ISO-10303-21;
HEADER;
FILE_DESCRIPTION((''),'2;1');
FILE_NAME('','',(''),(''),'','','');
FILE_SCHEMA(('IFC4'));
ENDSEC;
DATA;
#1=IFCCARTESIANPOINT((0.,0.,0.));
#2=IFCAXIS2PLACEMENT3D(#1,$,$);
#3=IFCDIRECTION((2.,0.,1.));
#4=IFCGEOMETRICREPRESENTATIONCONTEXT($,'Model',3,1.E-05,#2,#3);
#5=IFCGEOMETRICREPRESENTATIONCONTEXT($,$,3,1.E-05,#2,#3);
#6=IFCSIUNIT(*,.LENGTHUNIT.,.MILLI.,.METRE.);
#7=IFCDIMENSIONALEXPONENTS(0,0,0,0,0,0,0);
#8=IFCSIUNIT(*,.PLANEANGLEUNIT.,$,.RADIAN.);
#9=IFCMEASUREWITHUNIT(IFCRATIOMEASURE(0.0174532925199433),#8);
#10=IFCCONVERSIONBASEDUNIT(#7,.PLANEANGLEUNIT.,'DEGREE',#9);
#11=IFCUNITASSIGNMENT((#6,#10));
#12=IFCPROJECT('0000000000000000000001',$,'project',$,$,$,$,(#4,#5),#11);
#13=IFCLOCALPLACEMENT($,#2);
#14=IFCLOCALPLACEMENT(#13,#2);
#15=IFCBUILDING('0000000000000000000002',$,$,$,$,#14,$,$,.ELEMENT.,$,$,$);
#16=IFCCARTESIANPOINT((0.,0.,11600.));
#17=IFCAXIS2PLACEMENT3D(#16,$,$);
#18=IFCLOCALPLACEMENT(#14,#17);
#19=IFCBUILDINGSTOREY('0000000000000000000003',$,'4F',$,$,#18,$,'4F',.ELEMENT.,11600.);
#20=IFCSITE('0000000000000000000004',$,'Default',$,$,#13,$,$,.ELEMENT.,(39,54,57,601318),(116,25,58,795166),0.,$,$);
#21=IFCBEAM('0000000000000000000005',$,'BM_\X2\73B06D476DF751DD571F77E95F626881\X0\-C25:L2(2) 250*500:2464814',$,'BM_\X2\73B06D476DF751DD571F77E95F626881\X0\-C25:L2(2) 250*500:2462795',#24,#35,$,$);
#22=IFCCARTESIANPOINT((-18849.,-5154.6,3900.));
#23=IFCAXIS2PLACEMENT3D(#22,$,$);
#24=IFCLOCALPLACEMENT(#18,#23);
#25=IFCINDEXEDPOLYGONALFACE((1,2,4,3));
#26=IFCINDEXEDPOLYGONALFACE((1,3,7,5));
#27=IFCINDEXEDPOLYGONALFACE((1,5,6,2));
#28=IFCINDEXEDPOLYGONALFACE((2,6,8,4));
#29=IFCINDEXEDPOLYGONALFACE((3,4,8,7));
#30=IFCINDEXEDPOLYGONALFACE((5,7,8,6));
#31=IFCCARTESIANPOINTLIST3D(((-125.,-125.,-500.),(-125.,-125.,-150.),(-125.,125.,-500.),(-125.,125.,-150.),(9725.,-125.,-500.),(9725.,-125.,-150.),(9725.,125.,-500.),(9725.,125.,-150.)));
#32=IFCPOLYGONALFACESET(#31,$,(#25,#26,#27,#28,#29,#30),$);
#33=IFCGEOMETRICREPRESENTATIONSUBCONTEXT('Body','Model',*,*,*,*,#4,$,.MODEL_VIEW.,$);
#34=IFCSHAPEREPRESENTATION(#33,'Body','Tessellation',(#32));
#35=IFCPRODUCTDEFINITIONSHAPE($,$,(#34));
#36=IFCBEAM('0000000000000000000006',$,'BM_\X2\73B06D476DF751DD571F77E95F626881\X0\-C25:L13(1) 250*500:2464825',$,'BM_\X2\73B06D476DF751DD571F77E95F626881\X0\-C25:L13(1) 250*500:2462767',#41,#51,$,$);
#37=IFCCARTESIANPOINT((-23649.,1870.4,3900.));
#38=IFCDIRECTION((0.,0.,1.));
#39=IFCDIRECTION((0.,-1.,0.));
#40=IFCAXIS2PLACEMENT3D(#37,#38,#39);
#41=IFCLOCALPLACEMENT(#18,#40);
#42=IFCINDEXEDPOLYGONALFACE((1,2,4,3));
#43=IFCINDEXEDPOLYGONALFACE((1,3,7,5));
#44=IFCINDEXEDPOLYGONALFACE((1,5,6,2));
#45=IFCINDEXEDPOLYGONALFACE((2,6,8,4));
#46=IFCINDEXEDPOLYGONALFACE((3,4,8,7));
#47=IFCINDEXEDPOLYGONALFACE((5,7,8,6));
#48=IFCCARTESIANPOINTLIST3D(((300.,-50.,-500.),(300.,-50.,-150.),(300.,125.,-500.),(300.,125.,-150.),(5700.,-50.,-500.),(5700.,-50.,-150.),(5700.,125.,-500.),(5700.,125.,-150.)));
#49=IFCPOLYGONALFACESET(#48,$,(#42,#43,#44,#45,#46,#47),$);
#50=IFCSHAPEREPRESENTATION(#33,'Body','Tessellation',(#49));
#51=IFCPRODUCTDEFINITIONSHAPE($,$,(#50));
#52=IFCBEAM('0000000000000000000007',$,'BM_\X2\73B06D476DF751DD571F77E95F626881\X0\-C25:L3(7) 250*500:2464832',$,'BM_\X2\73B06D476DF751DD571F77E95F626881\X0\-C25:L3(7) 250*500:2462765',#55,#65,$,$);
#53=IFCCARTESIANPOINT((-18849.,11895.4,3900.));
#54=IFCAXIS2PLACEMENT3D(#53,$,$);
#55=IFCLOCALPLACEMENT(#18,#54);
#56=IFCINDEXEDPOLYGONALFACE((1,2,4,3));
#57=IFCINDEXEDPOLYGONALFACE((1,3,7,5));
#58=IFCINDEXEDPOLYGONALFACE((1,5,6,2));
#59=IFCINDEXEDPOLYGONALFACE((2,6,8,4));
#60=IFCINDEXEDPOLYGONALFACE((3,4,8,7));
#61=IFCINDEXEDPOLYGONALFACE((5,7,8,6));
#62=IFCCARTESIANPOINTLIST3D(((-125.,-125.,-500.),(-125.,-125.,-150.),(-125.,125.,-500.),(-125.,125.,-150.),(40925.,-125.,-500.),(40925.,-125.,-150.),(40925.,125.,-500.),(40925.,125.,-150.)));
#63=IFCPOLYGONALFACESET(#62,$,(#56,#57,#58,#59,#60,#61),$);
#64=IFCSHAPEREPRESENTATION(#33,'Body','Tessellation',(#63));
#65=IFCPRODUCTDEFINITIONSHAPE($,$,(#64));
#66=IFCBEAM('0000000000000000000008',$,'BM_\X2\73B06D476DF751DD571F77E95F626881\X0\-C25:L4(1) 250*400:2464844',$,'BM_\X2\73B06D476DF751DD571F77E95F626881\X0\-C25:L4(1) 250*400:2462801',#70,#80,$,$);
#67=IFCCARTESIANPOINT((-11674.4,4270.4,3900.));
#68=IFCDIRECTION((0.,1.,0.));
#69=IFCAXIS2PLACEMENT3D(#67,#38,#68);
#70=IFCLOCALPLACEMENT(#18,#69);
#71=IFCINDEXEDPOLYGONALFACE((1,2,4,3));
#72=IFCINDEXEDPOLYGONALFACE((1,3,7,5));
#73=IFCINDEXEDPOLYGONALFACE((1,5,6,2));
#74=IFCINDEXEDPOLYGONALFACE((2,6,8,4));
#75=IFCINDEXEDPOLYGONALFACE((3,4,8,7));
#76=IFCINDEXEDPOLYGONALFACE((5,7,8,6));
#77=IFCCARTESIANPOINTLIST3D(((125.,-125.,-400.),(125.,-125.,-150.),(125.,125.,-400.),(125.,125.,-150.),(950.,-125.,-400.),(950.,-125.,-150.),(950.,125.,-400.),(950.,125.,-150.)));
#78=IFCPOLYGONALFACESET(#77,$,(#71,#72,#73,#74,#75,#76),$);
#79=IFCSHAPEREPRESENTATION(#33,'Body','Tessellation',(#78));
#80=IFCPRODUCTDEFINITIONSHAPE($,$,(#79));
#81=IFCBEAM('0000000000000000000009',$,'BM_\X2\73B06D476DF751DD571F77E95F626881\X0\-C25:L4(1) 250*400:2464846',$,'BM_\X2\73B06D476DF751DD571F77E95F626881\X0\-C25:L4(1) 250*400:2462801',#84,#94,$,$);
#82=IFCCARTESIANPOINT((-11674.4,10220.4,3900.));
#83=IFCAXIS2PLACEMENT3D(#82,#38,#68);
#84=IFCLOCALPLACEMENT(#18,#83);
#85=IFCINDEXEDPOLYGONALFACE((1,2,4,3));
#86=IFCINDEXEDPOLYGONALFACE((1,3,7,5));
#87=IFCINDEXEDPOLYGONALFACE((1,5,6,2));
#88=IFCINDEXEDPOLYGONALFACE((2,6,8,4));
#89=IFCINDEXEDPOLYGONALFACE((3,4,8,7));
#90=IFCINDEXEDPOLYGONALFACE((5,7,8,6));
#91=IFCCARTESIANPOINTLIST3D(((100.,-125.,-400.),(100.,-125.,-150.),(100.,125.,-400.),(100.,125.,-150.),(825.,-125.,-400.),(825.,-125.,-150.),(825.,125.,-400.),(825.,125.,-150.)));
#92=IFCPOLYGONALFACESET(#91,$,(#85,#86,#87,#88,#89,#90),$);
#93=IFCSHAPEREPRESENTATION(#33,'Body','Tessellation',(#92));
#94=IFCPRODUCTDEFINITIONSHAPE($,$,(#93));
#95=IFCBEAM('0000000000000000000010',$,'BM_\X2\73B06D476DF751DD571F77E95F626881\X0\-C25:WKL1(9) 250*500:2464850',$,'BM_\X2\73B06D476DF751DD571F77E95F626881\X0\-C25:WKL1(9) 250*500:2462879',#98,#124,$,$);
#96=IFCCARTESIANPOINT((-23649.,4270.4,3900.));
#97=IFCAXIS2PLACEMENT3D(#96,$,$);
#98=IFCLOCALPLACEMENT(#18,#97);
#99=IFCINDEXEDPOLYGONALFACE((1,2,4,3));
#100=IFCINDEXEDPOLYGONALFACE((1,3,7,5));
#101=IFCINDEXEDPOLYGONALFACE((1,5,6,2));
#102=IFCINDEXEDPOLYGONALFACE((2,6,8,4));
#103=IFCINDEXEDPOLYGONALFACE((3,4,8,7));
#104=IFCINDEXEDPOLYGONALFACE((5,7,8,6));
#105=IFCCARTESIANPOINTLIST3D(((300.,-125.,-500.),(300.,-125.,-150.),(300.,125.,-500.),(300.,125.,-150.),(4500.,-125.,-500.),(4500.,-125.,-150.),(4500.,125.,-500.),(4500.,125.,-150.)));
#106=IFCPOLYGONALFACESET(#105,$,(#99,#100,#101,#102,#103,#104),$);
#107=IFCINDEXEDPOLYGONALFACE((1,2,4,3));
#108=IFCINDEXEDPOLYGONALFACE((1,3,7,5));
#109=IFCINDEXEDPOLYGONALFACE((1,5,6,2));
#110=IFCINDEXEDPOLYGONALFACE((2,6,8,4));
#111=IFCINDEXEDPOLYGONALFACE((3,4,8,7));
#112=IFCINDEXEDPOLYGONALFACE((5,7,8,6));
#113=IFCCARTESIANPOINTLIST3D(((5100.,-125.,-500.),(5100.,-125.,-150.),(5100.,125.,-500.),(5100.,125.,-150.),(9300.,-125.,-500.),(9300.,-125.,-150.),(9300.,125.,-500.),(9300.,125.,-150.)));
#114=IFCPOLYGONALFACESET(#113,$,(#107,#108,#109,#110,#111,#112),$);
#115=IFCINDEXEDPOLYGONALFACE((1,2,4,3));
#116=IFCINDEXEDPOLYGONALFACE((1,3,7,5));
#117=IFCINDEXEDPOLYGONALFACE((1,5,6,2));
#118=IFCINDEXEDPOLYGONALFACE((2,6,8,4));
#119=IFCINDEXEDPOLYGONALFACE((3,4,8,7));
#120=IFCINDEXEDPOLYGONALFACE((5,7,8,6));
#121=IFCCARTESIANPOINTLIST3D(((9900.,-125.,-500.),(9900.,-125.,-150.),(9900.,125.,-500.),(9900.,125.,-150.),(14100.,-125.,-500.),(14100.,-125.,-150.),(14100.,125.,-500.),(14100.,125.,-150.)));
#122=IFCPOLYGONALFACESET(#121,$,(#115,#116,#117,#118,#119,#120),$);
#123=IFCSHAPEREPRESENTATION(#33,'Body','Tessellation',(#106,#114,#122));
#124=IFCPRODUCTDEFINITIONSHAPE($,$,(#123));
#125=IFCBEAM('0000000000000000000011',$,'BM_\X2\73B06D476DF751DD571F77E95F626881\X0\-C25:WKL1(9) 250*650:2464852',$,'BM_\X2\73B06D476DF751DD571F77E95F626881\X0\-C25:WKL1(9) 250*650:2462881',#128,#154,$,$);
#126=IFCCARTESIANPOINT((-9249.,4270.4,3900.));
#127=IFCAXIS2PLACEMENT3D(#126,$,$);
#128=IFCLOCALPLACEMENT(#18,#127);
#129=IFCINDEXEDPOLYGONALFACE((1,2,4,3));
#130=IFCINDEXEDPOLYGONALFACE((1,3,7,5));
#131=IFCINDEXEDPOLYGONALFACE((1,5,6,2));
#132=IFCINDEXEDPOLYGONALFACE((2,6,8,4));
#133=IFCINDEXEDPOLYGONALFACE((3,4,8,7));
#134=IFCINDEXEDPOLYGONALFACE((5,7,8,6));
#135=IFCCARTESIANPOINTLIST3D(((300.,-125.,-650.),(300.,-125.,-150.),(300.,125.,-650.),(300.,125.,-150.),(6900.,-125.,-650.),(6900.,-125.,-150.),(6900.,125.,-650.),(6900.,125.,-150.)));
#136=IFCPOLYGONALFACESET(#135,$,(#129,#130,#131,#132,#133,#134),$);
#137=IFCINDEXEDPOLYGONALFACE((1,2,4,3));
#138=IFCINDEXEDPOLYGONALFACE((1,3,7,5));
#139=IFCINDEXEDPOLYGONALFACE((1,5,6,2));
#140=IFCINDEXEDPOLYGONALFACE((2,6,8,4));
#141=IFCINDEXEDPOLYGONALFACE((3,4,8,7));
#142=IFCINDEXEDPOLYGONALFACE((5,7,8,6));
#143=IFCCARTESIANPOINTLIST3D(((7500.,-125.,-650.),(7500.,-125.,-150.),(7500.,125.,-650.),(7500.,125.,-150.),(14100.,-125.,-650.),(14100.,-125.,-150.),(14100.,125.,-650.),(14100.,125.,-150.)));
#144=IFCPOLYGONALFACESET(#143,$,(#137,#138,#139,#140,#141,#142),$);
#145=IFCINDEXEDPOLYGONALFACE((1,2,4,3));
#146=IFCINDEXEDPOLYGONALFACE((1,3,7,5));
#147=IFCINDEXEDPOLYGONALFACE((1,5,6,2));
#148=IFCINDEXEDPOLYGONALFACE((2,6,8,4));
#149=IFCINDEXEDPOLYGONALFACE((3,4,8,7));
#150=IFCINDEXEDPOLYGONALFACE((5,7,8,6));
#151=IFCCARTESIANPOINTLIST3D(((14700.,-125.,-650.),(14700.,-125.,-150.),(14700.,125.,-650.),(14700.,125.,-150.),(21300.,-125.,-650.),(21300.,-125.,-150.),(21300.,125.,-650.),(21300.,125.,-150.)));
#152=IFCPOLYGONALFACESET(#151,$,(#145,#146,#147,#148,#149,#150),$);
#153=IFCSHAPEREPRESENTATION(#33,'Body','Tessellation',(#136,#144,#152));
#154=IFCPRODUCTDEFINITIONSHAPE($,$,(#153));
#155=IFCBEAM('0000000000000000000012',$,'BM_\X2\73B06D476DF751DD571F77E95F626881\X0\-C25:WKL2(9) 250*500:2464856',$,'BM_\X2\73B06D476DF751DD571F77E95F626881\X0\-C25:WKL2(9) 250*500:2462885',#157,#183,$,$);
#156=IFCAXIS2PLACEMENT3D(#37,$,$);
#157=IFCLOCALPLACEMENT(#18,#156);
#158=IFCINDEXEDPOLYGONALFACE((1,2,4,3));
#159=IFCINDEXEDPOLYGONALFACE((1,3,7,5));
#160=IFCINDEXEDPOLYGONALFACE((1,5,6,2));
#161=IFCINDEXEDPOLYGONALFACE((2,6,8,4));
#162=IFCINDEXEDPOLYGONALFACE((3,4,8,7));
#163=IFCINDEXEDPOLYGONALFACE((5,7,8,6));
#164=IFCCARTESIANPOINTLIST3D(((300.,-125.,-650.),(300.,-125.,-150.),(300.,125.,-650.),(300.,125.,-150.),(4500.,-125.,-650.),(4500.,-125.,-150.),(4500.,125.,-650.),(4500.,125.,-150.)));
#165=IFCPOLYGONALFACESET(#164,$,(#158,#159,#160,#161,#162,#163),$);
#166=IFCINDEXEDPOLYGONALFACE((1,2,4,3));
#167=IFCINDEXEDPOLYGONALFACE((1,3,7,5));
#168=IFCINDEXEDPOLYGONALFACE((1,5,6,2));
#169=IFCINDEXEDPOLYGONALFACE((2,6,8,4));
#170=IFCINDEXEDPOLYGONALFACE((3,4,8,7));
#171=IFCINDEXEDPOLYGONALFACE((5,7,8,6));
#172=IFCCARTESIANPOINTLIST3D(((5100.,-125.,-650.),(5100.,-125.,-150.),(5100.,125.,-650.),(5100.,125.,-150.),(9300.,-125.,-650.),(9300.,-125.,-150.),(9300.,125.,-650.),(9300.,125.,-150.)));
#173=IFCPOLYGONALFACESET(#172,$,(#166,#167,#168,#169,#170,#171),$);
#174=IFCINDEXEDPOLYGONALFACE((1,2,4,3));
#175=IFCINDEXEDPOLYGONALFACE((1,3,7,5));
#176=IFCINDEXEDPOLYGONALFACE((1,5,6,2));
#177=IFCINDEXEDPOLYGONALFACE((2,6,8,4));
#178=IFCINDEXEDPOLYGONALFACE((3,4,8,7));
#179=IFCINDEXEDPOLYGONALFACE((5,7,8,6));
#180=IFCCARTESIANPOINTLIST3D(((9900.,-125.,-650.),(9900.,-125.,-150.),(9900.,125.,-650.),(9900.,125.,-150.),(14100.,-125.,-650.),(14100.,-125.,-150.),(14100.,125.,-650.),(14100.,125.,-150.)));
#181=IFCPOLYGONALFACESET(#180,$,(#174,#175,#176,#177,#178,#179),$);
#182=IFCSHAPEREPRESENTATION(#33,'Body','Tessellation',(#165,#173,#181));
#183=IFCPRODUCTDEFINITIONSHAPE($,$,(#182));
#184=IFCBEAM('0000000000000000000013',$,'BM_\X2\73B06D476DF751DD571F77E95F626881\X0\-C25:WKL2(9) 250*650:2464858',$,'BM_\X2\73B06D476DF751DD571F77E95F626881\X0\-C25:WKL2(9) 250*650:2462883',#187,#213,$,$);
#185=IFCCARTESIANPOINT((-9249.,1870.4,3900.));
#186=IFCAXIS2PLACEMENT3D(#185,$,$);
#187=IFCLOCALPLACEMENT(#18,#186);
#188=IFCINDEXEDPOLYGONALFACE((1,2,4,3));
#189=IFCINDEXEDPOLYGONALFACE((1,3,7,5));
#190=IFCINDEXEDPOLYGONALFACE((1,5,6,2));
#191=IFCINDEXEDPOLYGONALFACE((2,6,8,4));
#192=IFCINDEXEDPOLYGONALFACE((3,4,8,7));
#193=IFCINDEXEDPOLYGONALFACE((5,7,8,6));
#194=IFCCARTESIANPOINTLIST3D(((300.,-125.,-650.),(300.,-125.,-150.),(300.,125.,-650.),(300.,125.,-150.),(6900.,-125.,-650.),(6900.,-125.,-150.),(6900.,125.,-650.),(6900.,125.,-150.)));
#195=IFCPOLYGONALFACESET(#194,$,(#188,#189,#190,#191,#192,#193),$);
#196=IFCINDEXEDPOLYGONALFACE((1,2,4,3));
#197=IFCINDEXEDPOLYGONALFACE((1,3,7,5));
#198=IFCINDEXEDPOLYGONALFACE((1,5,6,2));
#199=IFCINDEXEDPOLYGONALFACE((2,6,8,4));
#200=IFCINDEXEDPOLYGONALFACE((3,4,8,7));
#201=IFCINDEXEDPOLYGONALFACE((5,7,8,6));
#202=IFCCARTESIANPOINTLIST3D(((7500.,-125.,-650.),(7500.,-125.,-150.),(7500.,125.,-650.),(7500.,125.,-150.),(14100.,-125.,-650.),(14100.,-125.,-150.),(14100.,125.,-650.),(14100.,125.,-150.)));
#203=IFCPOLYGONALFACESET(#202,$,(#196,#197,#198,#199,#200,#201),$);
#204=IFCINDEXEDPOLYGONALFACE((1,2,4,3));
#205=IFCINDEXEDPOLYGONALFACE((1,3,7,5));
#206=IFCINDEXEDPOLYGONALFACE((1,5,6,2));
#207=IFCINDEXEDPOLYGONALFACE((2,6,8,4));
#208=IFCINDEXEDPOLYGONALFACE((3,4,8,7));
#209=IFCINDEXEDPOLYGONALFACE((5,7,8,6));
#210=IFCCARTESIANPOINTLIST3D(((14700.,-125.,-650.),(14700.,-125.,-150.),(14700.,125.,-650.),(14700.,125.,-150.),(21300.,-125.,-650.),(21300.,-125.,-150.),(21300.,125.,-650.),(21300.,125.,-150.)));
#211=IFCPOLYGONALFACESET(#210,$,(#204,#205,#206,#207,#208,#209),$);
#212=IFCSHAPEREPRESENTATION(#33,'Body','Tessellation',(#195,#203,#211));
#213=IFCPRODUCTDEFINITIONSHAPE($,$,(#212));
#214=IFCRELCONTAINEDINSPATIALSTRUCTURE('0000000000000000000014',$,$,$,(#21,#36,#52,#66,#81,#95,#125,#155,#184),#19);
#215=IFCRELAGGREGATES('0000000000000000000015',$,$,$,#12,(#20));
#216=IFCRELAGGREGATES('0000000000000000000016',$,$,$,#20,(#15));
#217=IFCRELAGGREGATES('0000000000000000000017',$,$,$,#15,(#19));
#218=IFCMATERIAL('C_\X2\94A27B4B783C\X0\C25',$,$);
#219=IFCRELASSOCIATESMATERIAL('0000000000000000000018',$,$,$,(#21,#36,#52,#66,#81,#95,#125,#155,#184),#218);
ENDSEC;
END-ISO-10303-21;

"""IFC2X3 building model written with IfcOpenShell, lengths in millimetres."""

from ifc_helpers import new_model, entity, si_unit, converted_unit, direction, frame, frame_2d, origin, origin_2d_with_axis, place, context, subcontext, project, spatial, rectangle, extrude, material, element, save


model = new_model("IFC2X3")

# Units and contexts
model_context = context("Model", 3, precision=1e-05, world=origin(), true_north=direction((2.0, 0.0, 1.0)))
context_of_model = context(None, 3, precision=1e-05, world=origin(), true_north=direction((2.0, 0.0, 1.0)))
body_context = subcontext(model_context, "Body", "Model", "MODEL_VIEW")
ifc_project = project(units=[si_unit("LENGTHUNIT", "METRE", prefix="MILLI"), converted_unit("PLANEANGLEUNIT", "DEGREE", entity("IfcRatioMeasure", 0.0174532925199433), si_unit("PLANEANGLEUNIT", "RADIAN"), dimensions=[0, 0, 0, 0, 0, 0, 0])], contexts=[model_context, context_of_model])

# Site, building, storey
site_placement = place(None, origin())
site = spatial("IfcSite", under=ifc_project, at=site_placement, Name="Default", CompositionType="ELEMENT", RefLatitude=(39, 54, 57, 601318), RefLongitude=(116, 25, 58, 795166), RefElevation=0.0)
building_placement = place(site_placement, origin())
building = spatial("IfcBuilding", under=site, at=building_placement, CompositionType="ELEMENT")
storey_placement = place(building_placement, frame((0.0, 0.0, 11600.0)))
storey = spatial("IfcBuildingStorey", under=building, at=storey_placement, Name="4F", LongName="4F", CompositionType="ELEMENT", Elevation=11600.0)

# Beams
ifc_material = material(Name="C_钢筋砼C25")
beam_1_placement = place(storey_placement, frame((-18849.0, -5154.6, 3900.0)))
element("IfcBeam", 1, at=beam_1_placement, inside=storey, material=ifc_material, Name="BM_现浇混凝土矩形梁-C25:L2(2) 250*500:2464814", ObjectType="BM_现浇混凝土矩形梁-C25:L2(2) 250*500:2462795", context=body_context, shape_type="SweptSolid", body=[
    extrude(rectangle(XDim=350.0, YDim=250.0, at=frame_2d((0.0, 0.0), x_axis=(1.0, 0.0))), frame((-125.0, 0.0, -325.0), z_axis=(1.0, 0.0, 0.0), x_axis=(0.0, 0.0, -1.0)), (0.0, 0.0, 1.0), 9850.0),
])
beam_2_placement = place(storey_placement, frame((-23649.0, 1870.4, 3900.0), z_axis=(0.0, 0.0, 1.0), x_axis=(0.0, -1.0, 0.0)))
element("IfcBeam", 2, at=beam_2_placement, inside=storey, material=ifc_material, Name="BM_现浇混凝土矩形梁-C25:L13(1) 250*500:2464825", ObjectType="BM_现浇混凝土矩形梁-C25:L13(1) 250*500:2462767", context=body_context, shape_type="SweptSolid", body=[
    extrude(rectangle(XDim=350.0, YDim=175.0, at=frame_2d((0.0, 0.0), x_axis=(1.0, 0.0))), frame((300.0, 37.5, -325.0), z_axis=(1.0, 0.0, 0.0), x_axis=(0.0, 0.0, -1.0)), (0.0, 0.0, 1.0), 5400.0),
])
beam_3_placement = place(storey_placement, frame((-18849.0, 11895.4, 3900.0)))
element("IfcBeam", 3, at=beam_3_placement, inside=storey, material=ifc_material, Name="BM_现浇混凝土矩形梁-C25:L3(7) 250*500:2464832", ObjectType="BM_现浇混凝土矩形梁-C25:L3(7) 250*500:2462765", context=body_context, shape_type="SweptSolid", body=[
    extrude(rectangle(XDim=350.0, YDim=250.0, at=frame_2d((0.0, 0.0), x_axis=(1.0, 0.0))), frame((-125.0, 0.0, -325.0), z_axis=(1.0, 0.0, 0.0), x_axis=(0.0, 0.0, -1.0)), (0.0, 0.0, 1.0), 41050.0),
])
beam_4_placement = place(storey_placement, frame((-11674.4, 4270.4, 3900.0), z_axis=(0.0, 0.0, 1.0), x_axis=(0.0, 1.0, 0.0)))
element("IfcBeam", 4, at=beam_4_placement, inside=storey, material=ifc_material, Name="BM_现浇混凝土矩形梁-C25:L4(1) 250*400:2464844", ObjectType="BM_现浇混凝土矩形梁-C25:L4(1) 250*400:2462801", context=body_context, shape_type="SweptSolid", body=[
    extrude(rectangle(XDim=250.0, YDim=250.0, at=frame_2d((0.0, 0.0), x_axis=(1.0, 0.0))), frame((125.0, 0.0, -275.0), z_axis=(1.0, 0.0, 0.0), x_axis=(0.0, 0.0, -1.0)), (0.0, 0.0, 1.0), 825.0),
])
beam_5_placement = place(storey_placement, frame((-11674.4, 10220.4, 3900.0), z_axis=(0.0, 0.0, 1.0), x_axis=(0.0, 1.0, 0.0)))
element("IfcBeam", 5, at=beam_5_placement, inside=storey, material=ifc_material, Name="BM_现浇混凝土矩形梁-C25:L4(1) 250*400:2464846", ObjectType="BM_现浇混凝土矩形梁-C25:L4(1) 250*400:2462801", context=body_context, shape_type="SweptSolid", body=[
    extrude(rectangle(XDim=250.0, YDim=250.0, at=frame_2d((0.0, 0.0), x_axis=(1.0, 0.0))), frame((100.0, 0.0, -275.0), z_axis=(1.0, 0.0, 0.0), x_axis=(0.0, 0.0, -1.0)), (0.0, 0.0, 1.0), 725.0),
])
beam_6_placement = place(storey_placement, frame((-23649.0, 4270.4, 3900.0)))
element("IfcBeam", 6, at=beam_6_placement, inside=storey, material=ifc_material, Name="BM_现浇混凝土矩形梁-C25:WKL1(9) 250*500:2464850", ObjectType="BM_现浇混凝土矩形梁-C25:WKL1(9) 250*500:2462879", context=body_context, shape_type="SweptSolid", body=[
    extrude(rectangle(XDim=350.0, YDim=250.0, at=frame_2d((0.0, 0.0), x_axis=(1.0, 0.0))), frame((300.0, 0.0, -325.0), z_axis=(1.0, 0.0, 0.0), x_axis=(0.0, 0.0, 1.0)), (0.0, 0.0, 1.0), 4200.0),
    extrude(rectangle(XDim=350.0, YDim=250.0, at=origin_2d_with_axis()), frame((5100.0, 0.0, -325.0), z_axis=(1.0, 0.0, 0.0), x_axis=(0.0, 0.0, 1.0)), (0.0, 0.0, 1.0), 4200.0),
    extrude(rectangle(XDim=350.0, YDim=250.0, at=frame_2d((0.0, 0.0), x_axis=(1.0, 0.0))), frame((9900.0, 0.0, -325.0), z_axis=(1.0, 0.0, 0.0), x_axis=(0.0, 0.0, 1.0)), (0.0, 0.0, 1.0), 4200.0),
])
beam_7_placement = place(storey_placement, frame((-9249.0, 4270.4, 3900.0)))
element("IfcBeam", 7, at=beam_7_placement, inside=storey, material=ifc_material, Name="BM_现浇混凝土矩形梁-C25:WKL1(9) 250*650:2464852", ObjectType="BM_现浇混凝土矩形梁-C25:WKL1(9) 250*650:2462881", context=body_context, shape_type="SweptSolid", body=[
    extrude(rectangle(XDim=500.0, YDim=250.0, at=frame_2d((0.0, 0.0), x_axis=(1.0, 0.0))), frame((300.0, 0.0, -400.0), z_axis=(1.0, 0.0, 0.0), x_axis=(0.0, 0.0, 1.0)), (0.0, 0.0, 1.0), 6600.0),
    extrude(rectangle(XDim=500.0, YDim=250.0, at=frame_2d((0.0, 0.0), x_axis=(1.0, 0.0))), frame((7500.0, 0.0, -400.0), z_axis=(1.0, 0.0, 0.0), x_axis=(0.0, 0.0, 1.0)), (0.0, 0.0, 1.0), 6600.0),
    extrude(rectangle(XDim=500.0, YDim=250.0, at=frame_2d((0.0, 0.0), x_axis=(1.0, 0.0))), frame((14700.0, 0.0, -400.0), z_axis=(1.0, 0.0, 0.0), x_axis=(0.0, 0.0, 1.0)), (0.0, 0.0, 1.0), 6600.0),
])
beam_8_placement = place(storey_placement, frame((-23649.0, 1870.4, 3900.0)))
element("IfcBeam", 8, at=beam_8_placement, inside=storey, material=ifc_material, Name="BM_现浇混凝土矩形梁-C25:WKL2(9) 250*500:2464856", ObjectType="BM_现浇混凝土矩形梁-C25:WKL2(9) 250*500:2462885", context=body_context, shape_type="SweptSolid", body=[
    extrude(rectangle(XDim=500.0, YDim=250.0, at=frame_2d((0.0, 0.0), x_axis=(1.0, 0.0))), frame((300.0, 0.0, -400.0), z_axis=(1.0, 0.0, 0.0), x_axis=(0.0, 0.0, 1.0)), (0.0, 0.0, 1.0), 4200.0),
    extrude(rectangle(XDim=500.0, YDim=250.0, at=frame_2d((0.0, 0.0), x_axis=(1.0, 0.0))), frame((5100.0, 0.0, -400.0), z_axis=(1.0, 0.0, 0.0), x_axis=(0.0, 0.0, 1.0)), (0.0, 0.0, 1.0), 4200.0),
    extrude(rectangle(XDim=500.0, YDim=250.0, at=frame_2d((0.0, 0.0), x_axis=(1.0, 0.0))), frame((9900.0, 0.0, -400.0), z_axis=(1.0, 0.0, 0.0), x_axis=(0.0, 0.0, 1.0)), (0.0, 0.0, 1.0), 4200.0),
])
beam_9_placement = place(storey_placement, frame((-9249.0, 1870.4, 3900.0)))
element("IfcBeam", 9, at=beam_9_placement, inside=storey, material=ifc_material, Name="BM_现浇混凝土矩形梁-C25:WKL2(9) 250*650:2464858", ObjectType="BM_现浇混凝土矩形梁-C25:WKL2(9) 250*650:2462883", context=body_context, shape_type="SweptSolid", body=[
    extrude(rectangle(XDim=500.0, YDim=250.0, at=frame_2d((0.0, 0.0), x_axis=(1.0, 0.0))), frame((300.0, 0.0, -400.0), z_axis=(1.0, 0.0, 0.0), x_axis=(0.0, 0.0, 1.0)), (0.0, 0.0, 1.0), 6600.0),
    extrude(rectangle(XDim=500.0, YDim=250.0, at=frame_2d((0.0, 0.0), x_axis=(1.0, 0.0))), frame((7500.0, 0.0, -400.0), z_axis=(1.0, 0.0, 0.0), x_axis=(0.0, 0.0, 1.0)), (0.0, 0.0, 1.0), 6600.0),
    extrude(rectangle(XDim=500.0, YDim=250.0, at=frame_2d((0.0, 0.0), x_axis=(1.0, 0.0))), frame((14700.0, 0.0, -400.0), z_axis=(1.0, 0.0, 0.0), x_axis=(0.0, 0.0, 1.0)), (0.0, 0.0, 1.0), 6600.0),
])

save(model, "model.ifc")
